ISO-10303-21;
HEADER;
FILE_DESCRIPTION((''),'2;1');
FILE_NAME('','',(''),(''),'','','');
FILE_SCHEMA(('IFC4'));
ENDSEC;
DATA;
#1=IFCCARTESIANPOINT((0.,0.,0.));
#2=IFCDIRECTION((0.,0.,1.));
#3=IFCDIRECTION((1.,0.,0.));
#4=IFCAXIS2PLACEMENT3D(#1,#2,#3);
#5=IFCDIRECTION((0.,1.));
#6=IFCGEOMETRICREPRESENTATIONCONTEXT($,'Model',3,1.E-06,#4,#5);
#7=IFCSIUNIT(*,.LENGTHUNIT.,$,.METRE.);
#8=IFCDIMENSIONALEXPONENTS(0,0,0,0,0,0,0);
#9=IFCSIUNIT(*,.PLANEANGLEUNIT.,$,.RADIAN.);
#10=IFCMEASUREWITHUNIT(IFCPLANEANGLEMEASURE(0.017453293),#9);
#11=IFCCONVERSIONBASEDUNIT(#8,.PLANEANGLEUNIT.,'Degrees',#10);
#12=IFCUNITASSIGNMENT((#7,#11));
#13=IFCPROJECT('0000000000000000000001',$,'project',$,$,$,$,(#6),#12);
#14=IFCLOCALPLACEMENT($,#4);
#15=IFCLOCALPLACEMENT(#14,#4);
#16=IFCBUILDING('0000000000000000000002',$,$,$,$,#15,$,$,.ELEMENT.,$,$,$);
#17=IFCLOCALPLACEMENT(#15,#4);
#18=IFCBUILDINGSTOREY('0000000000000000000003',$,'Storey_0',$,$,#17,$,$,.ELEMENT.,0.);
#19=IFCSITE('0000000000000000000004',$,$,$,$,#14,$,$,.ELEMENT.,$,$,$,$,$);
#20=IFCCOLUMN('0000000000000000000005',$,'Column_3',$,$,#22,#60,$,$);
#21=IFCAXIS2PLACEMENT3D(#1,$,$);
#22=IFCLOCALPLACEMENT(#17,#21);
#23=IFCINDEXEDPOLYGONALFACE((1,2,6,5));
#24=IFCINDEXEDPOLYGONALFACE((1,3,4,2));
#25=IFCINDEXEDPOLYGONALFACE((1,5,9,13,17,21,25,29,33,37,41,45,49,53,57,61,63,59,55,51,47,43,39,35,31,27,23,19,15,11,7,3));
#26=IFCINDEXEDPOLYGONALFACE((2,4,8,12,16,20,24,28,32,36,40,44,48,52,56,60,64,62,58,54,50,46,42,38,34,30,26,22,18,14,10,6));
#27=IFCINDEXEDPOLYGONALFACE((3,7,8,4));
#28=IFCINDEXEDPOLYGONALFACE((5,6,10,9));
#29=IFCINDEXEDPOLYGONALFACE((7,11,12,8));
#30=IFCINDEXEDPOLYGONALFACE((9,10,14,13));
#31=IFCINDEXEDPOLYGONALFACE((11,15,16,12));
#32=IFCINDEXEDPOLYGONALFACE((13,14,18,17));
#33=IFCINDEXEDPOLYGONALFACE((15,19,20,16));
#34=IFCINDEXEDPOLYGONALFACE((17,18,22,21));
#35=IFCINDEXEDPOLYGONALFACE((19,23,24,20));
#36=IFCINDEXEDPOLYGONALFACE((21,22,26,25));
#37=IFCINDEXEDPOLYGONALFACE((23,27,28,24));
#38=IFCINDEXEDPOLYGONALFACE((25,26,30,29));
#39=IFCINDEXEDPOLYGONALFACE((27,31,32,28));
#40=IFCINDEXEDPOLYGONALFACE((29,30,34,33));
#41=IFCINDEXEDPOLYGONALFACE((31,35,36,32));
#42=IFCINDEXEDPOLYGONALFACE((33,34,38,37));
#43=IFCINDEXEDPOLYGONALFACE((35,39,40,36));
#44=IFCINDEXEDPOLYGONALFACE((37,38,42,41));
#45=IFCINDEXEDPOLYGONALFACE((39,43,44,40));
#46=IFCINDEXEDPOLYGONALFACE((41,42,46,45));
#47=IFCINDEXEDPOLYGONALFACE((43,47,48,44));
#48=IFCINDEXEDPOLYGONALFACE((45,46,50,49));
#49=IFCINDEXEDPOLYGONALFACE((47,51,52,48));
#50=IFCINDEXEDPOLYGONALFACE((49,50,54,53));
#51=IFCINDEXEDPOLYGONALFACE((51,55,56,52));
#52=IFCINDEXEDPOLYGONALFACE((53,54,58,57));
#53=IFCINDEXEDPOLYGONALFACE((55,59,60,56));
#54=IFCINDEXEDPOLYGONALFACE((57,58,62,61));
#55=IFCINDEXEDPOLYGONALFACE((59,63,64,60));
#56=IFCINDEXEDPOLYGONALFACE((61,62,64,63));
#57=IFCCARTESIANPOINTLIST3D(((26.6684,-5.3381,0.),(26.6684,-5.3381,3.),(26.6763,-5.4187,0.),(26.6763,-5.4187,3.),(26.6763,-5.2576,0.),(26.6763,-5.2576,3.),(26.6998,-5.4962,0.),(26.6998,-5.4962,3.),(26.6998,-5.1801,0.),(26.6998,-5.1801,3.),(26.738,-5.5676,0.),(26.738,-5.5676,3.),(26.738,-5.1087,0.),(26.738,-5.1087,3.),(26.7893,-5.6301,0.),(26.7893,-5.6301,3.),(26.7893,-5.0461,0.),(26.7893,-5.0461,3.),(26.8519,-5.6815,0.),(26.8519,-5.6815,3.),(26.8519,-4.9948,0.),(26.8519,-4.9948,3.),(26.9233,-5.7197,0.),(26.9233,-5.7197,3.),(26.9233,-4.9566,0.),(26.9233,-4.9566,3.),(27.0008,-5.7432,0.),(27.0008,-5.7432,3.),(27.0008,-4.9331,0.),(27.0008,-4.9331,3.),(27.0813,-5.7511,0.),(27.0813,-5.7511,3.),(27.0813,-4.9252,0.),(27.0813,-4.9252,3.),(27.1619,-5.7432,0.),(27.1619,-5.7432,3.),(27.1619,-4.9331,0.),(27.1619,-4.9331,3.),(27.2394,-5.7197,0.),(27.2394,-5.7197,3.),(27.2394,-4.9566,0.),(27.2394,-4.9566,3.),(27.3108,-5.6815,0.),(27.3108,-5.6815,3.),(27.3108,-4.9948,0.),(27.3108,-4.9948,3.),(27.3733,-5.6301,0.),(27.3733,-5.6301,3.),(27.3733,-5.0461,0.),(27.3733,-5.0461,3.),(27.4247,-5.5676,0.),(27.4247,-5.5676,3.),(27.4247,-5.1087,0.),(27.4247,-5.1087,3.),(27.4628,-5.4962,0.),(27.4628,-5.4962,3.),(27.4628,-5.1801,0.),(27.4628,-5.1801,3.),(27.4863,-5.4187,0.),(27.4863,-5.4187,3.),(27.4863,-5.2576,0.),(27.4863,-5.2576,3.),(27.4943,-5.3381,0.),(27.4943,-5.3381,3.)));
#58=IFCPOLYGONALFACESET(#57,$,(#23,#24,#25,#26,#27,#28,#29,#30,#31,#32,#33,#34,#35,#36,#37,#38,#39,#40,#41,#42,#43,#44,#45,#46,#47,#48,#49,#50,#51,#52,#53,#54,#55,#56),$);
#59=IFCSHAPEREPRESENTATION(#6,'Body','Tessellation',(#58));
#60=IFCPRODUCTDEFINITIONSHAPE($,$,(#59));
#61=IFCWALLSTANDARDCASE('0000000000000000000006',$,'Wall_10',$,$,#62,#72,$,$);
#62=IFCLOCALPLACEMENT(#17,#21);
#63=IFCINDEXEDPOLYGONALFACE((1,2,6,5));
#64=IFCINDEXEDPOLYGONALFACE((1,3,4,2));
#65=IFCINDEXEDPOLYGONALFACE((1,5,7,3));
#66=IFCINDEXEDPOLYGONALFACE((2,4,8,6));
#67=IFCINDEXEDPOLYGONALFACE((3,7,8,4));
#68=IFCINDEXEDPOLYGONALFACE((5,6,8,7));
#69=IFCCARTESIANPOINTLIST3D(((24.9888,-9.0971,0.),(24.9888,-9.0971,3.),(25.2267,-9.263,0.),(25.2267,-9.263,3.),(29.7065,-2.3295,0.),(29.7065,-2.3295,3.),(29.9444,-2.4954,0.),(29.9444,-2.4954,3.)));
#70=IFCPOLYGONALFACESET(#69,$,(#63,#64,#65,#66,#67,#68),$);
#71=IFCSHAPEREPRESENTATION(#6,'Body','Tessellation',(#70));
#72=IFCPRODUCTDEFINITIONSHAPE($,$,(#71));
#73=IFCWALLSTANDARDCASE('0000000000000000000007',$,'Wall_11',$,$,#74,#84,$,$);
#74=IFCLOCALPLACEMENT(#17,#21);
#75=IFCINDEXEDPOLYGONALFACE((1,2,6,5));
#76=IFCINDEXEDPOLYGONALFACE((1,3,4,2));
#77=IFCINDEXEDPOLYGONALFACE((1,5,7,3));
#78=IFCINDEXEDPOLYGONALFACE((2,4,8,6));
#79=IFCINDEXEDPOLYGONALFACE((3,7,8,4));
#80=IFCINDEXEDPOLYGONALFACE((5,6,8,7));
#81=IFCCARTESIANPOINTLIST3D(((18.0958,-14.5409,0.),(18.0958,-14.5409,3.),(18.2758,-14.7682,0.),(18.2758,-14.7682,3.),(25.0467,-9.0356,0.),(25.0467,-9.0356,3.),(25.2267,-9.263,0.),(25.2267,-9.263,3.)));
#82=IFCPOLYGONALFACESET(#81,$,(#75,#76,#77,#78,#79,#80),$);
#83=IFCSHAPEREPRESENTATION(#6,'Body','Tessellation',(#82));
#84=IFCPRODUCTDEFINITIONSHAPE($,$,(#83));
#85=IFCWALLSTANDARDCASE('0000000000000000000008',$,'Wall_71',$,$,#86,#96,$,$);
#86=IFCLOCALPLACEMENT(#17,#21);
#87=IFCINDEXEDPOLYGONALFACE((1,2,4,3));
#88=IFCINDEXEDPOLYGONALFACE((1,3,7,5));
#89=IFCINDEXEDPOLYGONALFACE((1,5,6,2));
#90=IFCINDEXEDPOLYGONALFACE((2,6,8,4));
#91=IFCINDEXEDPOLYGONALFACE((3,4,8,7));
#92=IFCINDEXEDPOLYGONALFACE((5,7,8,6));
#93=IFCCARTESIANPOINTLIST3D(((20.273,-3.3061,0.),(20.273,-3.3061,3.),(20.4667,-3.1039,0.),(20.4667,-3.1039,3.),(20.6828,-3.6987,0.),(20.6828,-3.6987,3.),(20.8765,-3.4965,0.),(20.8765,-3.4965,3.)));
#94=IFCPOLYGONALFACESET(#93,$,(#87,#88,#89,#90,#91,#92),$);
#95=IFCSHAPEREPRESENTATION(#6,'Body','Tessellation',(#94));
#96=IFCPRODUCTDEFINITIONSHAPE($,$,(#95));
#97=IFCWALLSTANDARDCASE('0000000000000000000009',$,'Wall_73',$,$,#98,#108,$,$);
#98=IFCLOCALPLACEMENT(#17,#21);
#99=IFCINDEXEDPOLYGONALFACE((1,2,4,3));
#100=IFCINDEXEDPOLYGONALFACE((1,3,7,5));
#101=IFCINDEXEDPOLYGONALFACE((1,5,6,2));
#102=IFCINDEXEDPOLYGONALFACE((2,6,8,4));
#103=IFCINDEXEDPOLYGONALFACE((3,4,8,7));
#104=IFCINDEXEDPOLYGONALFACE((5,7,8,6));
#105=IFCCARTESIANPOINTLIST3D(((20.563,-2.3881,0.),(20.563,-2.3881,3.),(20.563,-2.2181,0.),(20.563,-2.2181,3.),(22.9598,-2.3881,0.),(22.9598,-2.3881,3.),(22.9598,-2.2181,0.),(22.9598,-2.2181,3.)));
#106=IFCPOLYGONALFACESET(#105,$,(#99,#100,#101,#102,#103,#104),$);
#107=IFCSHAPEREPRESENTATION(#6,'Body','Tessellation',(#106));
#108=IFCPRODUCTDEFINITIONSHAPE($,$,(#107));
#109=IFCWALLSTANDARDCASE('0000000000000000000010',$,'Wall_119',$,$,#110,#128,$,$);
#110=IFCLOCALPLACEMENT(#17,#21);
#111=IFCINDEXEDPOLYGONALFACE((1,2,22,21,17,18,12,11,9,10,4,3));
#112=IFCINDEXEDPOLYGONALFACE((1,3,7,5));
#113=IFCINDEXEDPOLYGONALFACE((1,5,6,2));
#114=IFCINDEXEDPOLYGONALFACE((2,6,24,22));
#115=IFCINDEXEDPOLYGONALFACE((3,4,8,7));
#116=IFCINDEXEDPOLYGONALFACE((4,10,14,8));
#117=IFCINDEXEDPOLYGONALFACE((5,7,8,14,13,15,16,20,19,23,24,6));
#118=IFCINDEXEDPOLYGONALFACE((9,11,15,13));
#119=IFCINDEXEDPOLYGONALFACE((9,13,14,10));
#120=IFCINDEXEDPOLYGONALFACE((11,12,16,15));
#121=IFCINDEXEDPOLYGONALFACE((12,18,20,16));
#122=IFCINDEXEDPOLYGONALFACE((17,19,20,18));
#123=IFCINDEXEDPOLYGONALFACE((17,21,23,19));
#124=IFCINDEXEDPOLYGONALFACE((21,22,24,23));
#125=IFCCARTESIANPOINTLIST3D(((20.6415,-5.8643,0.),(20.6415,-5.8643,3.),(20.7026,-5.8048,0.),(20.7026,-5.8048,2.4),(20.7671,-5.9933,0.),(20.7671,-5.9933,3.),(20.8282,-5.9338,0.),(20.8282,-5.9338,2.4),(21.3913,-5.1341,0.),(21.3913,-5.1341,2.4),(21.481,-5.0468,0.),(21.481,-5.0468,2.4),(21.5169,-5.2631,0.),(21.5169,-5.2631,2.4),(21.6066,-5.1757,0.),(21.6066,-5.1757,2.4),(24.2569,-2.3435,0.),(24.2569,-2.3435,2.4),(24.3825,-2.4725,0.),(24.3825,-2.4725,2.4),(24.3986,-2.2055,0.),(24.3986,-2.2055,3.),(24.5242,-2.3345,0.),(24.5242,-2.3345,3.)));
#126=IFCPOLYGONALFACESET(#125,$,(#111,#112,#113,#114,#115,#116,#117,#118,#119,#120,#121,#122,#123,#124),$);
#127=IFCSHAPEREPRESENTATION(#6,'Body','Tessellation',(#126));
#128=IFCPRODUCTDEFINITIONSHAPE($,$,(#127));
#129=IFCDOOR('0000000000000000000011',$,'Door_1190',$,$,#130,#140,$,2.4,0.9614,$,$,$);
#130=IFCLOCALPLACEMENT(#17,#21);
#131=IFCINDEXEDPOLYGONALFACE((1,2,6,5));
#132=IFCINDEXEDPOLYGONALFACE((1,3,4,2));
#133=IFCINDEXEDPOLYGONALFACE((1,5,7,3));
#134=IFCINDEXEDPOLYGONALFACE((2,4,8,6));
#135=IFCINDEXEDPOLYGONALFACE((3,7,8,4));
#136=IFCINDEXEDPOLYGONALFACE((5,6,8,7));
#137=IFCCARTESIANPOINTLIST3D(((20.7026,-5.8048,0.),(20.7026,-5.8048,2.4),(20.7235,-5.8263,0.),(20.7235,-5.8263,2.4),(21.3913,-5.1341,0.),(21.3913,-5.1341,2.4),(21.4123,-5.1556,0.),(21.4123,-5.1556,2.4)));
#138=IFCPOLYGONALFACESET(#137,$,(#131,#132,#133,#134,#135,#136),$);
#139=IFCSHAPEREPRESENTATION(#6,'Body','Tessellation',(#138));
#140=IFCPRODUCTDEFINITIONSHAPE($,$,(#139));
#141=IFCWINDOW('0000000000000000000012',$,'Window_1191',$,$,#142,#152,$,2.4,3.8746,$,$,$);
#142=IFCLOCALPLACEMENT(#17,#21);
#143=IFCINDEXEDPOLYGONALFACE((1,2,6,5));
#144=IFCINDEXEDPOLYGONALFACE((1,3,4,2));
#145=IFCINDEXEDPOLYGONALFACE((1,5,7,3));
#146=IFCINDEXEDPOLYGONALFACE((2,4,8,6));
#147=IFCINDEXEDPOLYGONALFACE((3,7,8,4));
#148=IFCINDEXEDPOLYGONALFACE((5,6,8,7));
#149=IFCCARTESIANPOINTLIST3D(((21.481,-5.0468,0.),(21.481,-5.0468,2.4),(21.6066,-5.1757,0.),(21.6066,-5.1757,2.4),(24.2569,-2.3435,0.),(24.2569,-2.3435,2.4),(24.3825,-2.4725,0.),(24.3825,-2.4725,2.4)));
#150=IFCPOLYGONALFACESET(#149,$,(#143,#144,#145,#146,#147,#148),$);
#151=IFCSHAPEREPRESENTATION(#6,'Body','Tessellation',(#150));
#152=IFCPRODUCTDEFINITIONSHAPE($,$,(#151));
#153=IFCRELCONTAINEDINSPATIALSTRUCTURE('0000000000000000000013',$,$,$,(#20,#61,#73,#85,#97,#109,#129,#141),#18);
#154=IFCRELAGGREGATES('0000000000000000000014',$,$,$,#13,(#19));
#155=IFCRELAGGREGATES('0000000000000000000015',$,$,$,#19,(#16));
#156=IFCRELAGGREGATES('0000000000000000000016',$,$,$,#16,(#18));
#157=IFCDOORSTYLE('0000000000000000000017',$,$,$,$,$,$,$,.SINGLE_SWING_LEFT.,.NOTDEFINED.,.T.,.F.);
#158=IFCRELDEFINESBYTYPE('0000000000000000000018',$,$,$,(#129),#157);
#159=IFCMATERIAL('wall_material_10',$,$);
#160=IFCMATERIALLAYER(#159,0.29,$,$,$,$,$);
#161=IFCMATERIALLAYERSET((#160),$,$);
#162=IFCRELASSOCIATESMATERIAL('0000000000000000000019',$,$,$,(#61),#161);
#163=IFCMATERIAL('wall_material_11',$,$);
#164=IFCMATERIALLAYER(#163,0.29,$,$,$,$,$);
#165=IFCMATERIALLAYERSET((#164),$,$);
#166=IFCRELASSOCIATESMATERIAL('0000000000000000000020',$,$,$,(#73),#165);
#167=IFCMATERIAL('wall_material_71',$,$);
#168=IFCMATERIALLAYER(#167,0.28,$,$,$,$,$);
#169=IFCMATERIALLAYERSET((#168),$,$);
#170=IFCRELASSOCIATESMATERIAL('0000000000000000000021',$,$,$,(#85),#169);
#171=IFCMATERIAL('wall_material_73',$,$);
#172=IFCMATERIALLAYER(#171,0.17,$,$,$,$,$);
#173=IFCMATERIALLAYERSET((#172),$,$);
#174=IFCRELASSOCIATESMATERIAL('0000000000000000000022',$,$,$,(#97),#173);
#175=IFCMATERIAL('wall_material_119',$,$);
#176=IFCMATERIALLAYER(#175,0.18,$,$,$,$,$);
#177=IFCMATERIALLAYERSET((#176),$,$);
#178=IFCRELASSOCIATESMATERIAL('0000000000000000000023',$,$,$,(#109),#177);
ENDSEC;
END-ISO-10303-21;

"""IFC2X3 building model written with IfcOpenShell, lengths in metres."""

from ifc_helpers import new_model, entity, si_unit, converted_unit, direction, frame, frame_2d, origin_with_axes, origin_2d_with_axis, place, context, project, spatial, polyline, rectangle, circle, outline, extrude, material, layer, layer_set, layer_usage, type_object, element, fill, save


model = new_model("IFC2X3")

# Units and contexts
model_context = context("Model", 3, precision=1e-06, world=origin_with_axes(), true_north=direction((0.0, 1.0)))
ifc_project = project(units=[si_unit("LENGTHUNIT", "METRE"), converted_unit("PLANEANGLEUNIT", "Degrees", entity("IfcPlaneAngleMeasure", 0.017453293), si_unit("PLANEANGLEUNIT", "RADIAN"), dimensions=[0, 0, 0, 0, 0, 0, 0])], contexts=[model_context])

# Site, building, storey
site_placement = place(None, origin_with_axes())
site = spatial("IfcSite", under=ifc_project, at=site_placement, CompositionType="ELEMENT")
building_placement = place(site_placement, origin_with_axes())
building = spatial("IfcBuilding", under=site, at=building_placement, CompositionType="ELEMENT")
storey_placement = place(building_placement, origin_with_axes())
storey = spatial("IfcBuildingStorey", under=building, at=storey_placement, Name="Storey_0", CompositionType="ELEMENT", Elevation=0.0)

# Column
column_placement = place(storey_placement, frame((27.0813, -5.3381, 0.0), z_axis=(0.0, 0.0, 1.0), x_axis=(1.0, 0.0, 0.0)))
element("IfcColumn", 1, at=column_placement, inside=storey, Name="Column_3", context=model_context, shape_type="SweptSolid", body=[
    extrude(circle(Radius=0.413, at=origin_2d_with_axis()), origin_with_axes(), (0.0, 0.0, 1.0), 3.0),
])

# Walls
ifc_material_1 = material(Name="wall_material_10")
ifc_layer_1 = layer(ifc_material_1, 0.29)
ifc_layer_set_1 = layer_set([ifc_layer_1])
ifc_layer_usage_1 = layer_usage(ifc_layer_set_1, "AXIS2", "NEGATIVE", 0.0)
wall_1_placement = place(storey_placement, frame((29.9444, -2.4954, 0.0), z_axis=(0.0, 0.0, 1.0), x_axis=(-0.571862, -0.82035, 0.0)))
element("IfcWallStandardCase", 2, at=wall_1_placement, inside=storey, material=ifc_layer_usage_1, Name="Wall_10", context=model_context, shape_type="SweptSolid", body=[
    extrude(outline(polyline([(0.0, 0.0), (8.2496, 0.0), (8.2496, -0.29), (0.0, -0.29), (0.0, 0.0)])), origin_with_axes(), (0.0, 0.0, 1.0), 3.0),
])
ifc_material_2 = material(Name="wall_material_11")
ifc_layer_2 = layer(ifc_material_2, 0.29)
ifc_layer_set_2 = layer_set([ifc_layer_2])
ifc_layer_usage_2 = layer_usage(ifc_layer_set_2, "AXIS2", "NEGATIVE", 0.0)
wall_2_placement = place(storey_placement, frame((25.2267, -9.263, 0.0), z_axis=(0.0, 0.0, 1.0), x_axis=(-0.78391, -0.620874, 0.0)))
element("IfcWallStandardCase", 3, at=wall_2_placement, inside=storey, material=ifc_layer_usage_2, Name="Wall_11", context=model_context, shape_type="SweptSolid", body=[
    extrude(outline(polyline([(0.0, 0.0), (8.867, 0.0), (8.867, -0.29), (0.0, -0.29), (0.0, 0.0)])), origin_with_axes(), (0.0, 0.0, 1.0), 3.0),
])
ifc_material_3 = material(Name="wall_material_71")
ifc_layer_3 = layer(ifc_material_3, 0.28)
ifc_layer_set_3 = layer_set([ifc_layer_3])
ifc_layer_usage_3 = layer_usage(ifc_layer_set_3, "AXIS2", "NEGATIVE", 0.0)
wall_3_placement = place(storey_placement, frame((20.6828, -3.6987, 0.0), z_axis=(0.0, 0.0, 1.0), x_axis=(-0.722057, 0.691834, 0.0)))
element("IfcWallStandardCase", 4, at=wall_3_placement, inside=storey, material=ifc_layer_usage_3, Name="Wall_71", context=model_context, shape_type="SweptSolid", body=[
    extrude(outline(polyline([(0.0, 0.0), (0.5675, 0.0), (0.5675, -0.28), (0.0, -0.28), (0.0, 0.0)])), origin_with_axes(), (0.0, 0.0, 1.0), 3.0),
])
ifc_material_4 = material(Name="wall_material_73")
ifc_layer_4 = layer(ifc_material_4, 0.17)
ifc_layer_set_4 = layer_set([ifc_layer_4])
ifc_layer_usage_4 = layer_usage(ifc_layer_set_4, "AXIS2", "NEGATIVE", 0.0)
wall_4_placement = place(storey_placement, frame((20.563, -2.2181, 0.0), z_axis=(0.0, 0.0, 1.0), x_axis=(1.0, 0.0, 0.0)))
element("IfcWallStandardCase", 5, at=wall_4_placement, inside=storey, material=ifc_layer_usage_4, Name="Wall_73", context=model_context, shape_type="SweptSolid", body=[
    extrude(outline(polyline([(0.0, 0.0), (2.3968, 0.0), (2.3968, -0.17), (0.0, -0.17), (0.0, 0.0)])), origin_with_axes(), (0.0, 0.0, 1.0), 3.0),
])

# Wall, openings, door, window
ifc_material_5 = material(Name="wall_material_119")
ifc_layer_5 = layer(ifc_material_5, 0.18)
ifc_layer_set_5 = layer_set([ifc_layer_5])
ifc_layer_usage_5 = layer_usage(ifc_layer_set_5, "AXIS2", "NEGATIVE", 0.0)
wall_5_placement = place(storey_placement, frame((20.6415, -5.8643, 0.0), z_axis=(0.0, 0.0, 1.0), x_axis=(0.716414, 0.697675, 0.0)))
wall_5 = element("IfcWallStandardCase", 6, at=wall_5_placement, inside=storey, material=ifc_layer_usage_5, Name="Wall_119", context=model_context, shape_type="SweptSolid", body=[
    extrude(outline(polyline([(0.0, 0.0), (5.2443, 0.0), (5.2443, -0.18), (0.0, -0.18), (0.0, 0.0)])), origin_with_axes(), (0.0, 0.0, 1.0), 3.0),
])
opening_1_placement = place(wall_5_placement, frame((0.0852, 0.0, 0.0), z_axis=(0.0, 0.0, 1.0), x_axis=(1.0, 0.0, 0.0)))
opening_1 = element("IfcOpeningElement", 7, at=opening_1_placement, cuts=wall_5, context=model_context, shape_type="SweptSolid", body=[
    extrude(rectangle(XDim=0.9614, YDim=2.4, at=frame_2d((1.2, -0.4807), x_axis=(0.0, 1.0))), frame((0.0, 0.01, 0.0), z_axis=(0.0, -1.0, 0.0), x_axis=(0.0, 0.0, 1.0)), (0.0, 0.0, 1.0), 0.2),
])
opening_2_placement = place(wall_5_placement, frame((1.1718, 0.0, 0.0), z_axis=(0.0, 0.0, 1.0), x_axis=(1.0, 0.0, 0.0)))
opening_2 = element("IfcOpeningElement", 8, at=opening_2_placement, cuts=wall_5, context=model_context, shape_type="SweptSolid", body=[
    extrude(rectangle(XDim=3.8746, YDim=2.4, at=frame_2d((1.2, -1.9373), x_axis=(0.0, 1.0))), frame((0.0, 0.01, 0.0), z_axis=(0.0, -1.0, 0.0), x_axis=(0.0, 0.0, 1.0)), (0.0, 0.0, 1.0), 0.2),
])
door_style_1 = type_object("IfcDoorStyle", ConstructionType="NOTDEFINED", OperationType="SINGLE_SWING_LEFT", ParameterTakesPrecedence=True, Sizeable=False)
door_1_placement = place(storey_placement, origin_with_axes())
door_1 = element("IfcDoor", 9, at=door_1_placement, inside=storey, type_object=door_style_1, Name="Door_1190", OverallHeight=2.4, OverallWidth=0.9614, context=model_context, shape_type="SweptSolid", body=[
    extrude(outline(polyline([(20.7026, -5.8048), (21.3913, -5.1341), (21.4123, -5.1556), (20.7235, -5.8263), (20.7026, -5.8048)])), origin_with_axes(), (0.0, 0.0, 1.0), 2.4),
])
fill(opening_1, door_1)
window_1_placement = place(storey_placement, origin_with_axes())
window_1 = element("IfcWindow", 10, at=window_1_placement, inside=storey, Name="Window_1191", OverallHeight=2.4, OverallWidth=3.8746, context=model_context, shape_type="SweptSolid", body=[
    extrude(outline(polyline([(21.481, -5.0468), (24.2569, -2.3435), (24.3825, -2.4725), (21.6066, -5.1757), (21.481, -5.0468)])), origin_with_axes(), (0.0, 0.0, 1.0), 2.4),
])
fill(opening_2, window_1)

save(model, "model.ifc")
